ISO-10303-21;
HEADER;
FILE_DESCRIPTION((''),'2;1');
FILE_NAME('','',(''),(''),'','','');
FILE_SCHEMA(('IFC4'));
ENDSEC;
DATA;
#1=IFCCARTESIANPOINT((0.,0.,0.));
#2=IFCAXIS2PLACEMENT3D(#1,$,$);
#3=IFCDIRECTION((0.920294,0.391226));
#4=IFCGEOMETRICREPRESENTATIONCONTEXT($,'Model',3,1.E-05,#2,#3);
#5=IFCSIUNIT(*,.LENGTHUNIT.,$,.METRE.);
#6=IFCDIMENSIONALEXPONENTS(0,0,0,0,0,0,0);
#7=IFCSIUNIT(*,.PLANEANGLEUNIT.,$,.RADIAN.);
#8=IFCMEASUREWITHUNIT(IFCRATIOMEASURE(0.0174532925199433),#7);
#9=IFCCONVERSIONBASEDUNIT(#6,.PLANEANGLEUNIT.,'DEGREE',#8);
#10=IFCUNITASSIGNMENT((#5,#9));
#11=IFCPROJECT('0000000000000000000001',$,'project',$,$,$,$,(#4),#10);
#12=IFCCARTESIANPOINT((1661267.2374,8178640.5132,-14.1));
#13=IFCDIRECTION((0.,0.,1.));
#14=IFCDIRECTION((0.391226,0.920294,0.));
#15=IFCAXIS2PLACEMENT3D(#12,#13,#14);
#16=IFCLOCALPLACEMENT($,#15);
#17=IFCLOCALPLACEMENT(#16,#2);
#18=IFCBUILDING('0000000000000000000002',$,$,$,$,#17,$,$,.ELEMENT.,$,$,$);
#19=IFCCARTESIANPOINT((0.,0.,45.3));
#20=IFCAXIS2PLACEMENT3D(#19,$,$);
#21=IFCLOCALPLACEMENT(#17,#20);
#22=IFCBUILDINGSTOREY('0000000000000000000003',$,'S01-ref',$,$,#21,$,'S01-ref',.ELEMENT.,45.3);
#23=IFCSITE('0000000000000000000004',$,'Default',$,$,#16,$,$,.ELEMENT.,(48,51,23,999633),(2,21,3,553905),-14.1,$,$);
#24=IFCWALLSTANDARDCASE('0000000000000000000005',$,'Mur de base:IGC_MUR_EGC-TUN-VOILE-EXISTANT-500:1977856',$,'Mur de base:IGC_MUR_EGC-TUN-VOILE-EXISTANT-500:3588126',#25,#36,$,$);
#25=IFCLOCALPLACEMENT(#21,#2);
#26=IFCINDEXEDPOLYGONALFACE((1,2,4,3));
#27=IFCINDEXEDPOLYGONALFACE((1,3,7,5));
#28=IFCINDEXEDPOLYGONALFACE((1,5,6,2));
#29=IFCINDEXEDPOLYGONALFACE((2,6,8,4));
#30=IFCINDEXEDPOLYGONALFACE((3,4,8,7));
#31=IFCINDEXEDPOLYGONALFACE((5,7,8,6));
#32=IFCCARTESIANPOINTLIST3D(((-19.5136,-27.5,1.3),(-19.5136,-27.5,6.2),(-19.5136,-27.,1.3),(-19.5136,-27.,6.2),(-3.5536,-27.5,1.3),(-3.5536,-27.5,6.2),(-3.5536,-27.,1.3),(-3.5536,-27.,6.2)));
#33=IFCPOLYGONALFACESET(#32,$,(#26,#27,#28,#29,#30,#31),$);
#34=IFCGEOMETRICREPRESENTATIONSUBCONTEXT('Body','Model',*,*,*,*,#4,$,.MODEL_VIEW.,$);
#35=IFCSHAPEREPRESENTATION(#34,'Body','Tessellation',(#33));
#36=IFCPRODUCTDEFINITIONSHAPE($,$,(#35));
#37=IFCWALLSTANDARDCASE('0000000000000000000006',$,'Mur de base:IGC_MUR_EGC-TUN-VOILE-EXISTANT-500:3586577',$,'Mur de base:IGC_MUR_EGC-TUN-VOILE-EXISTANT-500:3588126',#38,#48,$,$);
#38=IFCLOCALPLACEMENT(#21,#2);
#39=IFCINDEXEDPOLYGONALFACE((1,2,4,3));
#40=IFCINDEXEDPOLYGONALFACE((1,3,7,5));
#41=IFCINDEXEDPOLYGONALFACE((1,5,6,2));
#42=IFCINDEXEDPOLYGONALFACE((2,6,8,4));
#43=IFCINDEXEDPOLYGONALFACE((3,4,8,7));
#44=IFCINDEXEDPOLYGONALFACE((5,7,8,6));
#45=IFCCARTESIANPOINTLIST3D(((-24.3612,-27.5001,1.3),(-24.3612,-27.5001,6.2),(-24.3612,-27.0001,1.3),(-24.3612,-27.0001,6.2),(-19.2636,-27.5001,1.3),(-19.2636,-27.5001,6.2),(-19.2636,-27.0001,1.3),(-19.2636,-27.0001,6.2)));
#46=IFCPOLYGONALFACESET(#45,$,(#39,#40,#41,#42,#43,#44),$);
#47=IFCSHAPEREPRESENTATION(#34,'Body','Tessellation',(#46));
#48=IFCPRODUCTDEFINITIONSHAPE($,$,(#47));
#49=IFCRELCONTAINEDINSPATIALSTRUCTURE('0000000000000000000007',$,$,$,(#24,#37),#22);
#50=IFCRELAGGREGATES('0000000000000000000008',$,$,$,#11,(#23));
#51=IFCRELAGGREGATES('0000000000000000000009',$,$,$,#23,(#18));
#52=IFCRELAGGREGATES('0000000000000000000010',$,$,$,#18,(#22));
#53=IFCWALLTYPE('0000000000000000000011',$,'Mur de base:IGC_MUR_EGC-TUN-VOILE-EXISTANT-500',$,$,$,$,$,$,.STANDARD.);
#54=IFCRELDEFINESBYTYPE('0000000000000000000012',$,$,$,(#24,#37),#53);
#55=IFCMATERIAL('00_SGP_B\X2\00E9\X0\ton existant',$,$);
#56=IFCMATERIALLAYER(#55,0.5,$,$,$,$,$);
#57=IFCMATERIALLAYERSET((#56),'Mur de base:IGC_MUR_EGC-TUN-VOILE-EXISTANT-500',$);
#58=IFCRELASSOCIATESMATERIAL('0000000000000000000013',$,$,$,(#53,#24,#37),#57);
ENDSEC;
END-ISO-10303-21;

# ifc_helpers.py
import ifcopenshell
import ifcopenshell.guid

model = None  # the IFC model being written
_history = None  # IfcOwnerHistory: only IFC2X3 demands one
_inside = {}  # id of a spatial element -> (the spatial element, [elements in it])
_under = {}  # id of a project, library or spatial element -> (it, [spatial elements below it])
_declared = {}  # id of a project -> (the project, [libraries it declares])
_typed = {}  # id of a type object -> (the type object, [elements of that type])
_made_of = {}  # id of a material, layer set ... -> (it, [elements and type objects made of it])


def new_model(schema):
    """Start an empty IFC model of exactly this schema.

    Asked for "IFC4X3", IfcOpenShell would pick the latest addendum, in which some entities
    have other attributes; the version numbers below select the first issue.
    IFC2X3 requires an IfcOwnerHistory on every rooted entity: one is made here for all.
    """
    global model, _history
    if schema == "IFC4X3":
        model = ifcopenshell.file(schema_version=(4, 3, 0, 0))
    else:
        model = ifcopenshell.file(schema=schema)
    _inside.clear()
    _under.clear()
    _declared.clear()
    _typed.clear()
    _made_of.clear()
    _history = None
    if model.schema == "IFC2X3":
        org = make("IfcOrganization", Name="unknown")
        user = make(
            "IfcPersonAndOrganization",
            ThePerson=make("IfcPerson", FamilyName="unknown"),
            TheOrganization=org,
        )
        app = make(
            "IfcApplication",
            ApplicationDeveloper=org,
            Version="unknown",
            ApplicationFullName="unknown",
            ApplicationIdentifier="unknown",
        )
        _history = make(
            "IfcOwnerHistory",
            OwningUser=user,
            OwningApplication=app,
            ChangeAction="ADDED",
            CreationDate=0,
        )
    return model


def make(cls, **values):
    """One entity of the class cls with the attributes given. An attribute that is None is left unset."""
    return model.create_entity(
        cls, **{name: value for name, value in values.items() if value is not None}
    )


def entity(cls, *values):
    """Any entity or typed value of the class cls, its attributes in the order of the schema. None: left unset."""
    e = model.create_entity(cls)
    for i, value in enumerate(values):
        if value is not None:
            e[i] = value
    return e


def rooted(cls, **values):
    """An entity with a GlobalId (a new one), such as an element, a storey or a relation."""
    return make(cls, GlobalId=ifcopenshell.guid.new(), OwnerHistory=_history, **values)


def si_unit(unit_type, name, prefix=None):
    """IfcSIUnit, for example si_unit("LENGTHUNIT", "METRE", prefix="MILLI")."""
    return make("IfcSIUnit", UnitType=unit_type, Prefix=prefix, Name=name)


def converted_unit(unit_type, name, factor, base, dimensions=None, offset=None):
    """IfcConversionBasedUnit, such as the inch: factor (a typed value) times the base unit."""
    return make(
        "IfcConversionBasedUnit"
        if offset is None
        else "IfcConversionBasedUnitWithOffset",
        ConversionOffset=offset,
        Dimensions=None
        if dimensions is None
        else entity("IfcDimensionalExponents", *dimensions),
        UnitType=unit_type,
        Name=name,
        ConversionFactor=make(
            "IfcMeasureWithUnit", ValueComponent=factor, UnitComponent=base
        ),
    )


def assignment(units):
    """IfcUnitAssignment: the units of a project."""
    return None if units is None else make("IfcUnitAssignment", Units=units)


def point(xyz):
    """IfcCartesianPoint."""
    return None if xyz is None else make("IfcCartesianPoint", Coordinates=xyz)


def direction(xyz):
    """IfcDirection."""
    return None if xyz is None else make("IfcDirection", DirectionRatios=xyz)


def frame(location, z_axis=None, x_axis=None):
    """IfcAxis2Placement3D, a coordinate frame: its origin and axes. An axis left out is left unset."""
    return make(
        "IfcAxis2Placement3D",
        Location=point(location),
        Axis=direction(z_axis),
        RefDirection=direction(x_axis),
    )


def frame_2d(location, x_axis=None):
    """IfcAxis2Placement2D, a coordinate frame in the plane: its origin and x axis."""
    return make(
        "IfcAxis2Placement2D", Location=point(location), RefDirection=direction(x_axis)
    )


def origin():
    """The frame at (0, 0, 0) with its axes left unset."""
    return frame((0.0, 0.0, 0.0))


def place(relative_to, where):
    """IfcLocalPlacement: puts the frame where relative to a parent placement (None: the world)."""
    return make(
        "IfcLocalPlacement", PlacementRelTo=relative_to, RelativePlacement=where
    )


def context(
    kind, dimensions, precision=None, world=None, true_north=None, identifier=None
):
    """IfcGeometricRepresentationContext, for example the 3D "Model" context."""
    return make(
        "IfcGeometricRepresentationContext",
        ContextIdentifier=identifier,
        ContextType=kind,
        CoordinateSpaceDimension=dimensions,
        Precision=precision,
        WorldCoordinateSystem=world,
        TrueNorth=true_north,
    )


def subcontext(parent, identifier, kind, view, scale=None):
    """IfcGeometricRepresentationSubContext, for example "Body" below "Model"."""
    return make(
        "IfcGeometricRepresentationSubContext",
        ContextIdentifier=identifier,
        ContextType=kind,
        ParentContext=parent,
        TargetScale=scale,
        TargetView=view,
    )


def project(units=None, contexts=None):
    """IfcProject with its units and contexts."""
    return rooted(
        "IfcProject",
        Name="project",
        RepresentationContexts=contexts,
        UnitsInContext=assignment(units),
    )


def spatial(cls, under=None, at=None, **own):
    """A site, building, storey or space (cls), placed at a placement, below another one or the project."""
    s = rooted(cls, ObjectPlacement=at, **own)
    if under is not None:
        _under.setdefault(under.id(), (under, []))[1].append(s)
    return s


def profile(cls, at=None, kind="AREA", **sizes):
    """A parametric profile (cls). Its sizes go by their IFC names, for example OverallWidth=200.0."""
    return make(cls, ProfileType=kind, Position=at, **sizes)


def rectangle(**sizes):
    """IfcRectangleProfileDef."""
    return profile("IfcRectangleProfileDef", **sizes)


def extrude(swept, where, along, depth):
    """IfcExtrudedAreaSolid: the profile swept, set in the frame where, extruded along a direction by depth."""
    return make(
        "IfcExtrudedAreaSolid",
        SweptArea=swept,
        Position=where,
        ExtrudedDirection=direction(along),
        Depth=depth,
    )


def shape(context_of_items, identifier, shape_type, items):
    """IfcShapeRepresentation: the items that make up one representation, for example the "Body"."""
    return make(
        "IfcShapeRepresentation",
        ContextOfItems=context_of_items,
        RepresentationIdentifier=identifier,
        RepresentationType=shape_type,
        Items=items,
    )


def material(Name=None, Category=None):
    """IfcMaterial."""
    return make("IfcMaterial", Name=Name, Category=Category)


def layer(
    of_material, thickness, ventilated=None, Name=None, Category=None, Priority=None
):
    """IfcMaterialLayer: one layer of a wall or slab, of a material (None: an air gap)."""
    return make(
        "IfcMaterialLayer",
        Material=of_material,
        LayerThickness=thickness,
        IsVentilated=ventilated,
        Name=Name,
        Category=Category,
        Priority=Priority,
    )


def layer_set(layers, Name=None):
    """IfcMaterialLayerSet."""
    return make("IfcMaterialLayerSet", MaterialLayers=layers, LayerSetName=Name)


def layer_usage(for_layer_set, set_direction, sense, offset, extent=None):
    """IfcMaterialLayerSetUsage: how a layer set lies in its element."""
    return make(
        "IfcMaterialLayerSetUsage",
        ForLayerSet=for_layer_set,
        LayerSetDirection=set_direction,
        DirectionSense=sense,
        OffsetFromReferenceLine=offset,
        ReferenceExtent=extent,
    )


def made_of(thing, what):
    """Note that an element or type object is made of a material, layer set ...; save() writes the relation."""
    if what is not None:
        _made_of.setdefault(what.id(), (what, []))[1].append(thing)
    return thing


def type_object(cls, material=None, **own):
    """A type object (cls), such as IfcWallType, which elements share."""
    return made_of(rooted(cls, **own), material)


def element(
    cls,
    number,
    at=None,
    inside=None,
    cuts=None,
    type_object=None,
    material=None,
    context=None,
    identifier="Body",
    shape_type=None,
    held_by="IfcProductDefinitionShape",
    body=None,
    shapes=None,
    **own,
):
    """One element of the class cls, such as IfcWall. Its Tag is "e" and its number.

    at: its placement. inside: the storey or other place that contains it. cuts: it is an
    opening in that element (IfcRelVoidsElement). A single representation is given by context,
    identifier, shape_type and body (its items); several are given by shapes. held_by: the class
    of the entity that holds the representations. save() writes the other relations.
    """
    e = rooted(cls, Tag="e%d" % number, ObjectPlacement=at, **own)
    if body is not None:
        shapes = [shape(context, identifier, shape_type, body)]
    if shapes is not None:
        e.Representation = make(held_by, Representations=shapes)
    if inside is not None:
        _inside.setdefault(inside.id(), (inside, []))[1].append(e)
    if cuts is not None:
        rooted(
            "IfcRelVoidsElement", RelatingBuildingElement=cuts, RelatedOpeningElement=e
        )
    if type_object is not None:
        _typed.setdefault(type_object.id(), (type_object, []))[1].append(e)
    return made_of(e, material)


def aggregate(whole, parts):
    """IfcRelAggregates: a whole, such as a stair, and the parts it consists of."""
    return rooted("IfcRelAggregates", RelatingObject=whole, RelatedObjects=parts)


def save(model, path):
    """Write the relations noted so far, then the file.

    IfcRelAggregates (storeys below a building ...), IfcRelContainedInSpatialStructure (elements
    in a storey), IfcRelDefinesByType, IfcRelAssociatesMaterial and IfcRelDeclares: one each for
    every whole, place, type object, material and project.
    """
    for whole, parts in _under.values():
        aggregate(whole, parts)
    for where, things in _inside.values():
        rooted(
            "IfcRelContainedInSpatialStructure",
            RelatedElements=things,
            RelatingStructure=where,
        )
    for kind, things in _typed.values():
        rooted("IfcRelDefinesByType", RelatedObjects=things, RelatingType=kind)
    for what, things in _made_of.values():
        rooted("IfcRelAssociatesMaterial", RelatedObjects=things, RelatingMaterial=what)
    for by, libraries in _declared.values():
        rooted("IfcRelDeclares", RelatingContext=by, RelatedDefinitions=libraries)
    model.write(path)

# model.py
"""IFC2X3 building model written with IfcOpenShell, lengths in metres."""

from ifc_helpers import new_model, entity, si_unit, converted_unit, direction, frame, frame_2d, origin, place, context, subcontext, project, spatial, rectangle, extrude, material, layer, layer_set, layer_usage, type_object, element, save


model = new_model("IFC2X3")

# Units and contexts
model_context = context("Model", 3, precision=1e-05, world=origin(), true_north=direction((0.920294, 0.391226)))
body_context = subcontext(model_context, "Body", "Model", "MODEL_VIEW")
ifc_project = project(units=[si_unit("LENGTHUNIT", "METRE"), converted_unit("PLANEANGLEUNIT", "DEGREE", entity("IfcRatioMeasure", 0.0174532925199433), si_unit("PLANEANGLEUNIT", "RADIAN"), dimensions=[0, 0, 0, 0, 0, 0, 0])], contexts=[model_context])

# Site, building, storey
site_placement = place(None, frame((1661267.2374, 8178640.5132, -14.1), z_axis=(0.0, 0.0, 1.0), x_axis=(0.391226, 0.920294, 0.0)))
site = spatial("IfcSite", under=ifc_project, at=site_placement, Name="Default", CompositionType="ELEMENT", RefLatitude=(48, 51, 23, 999633), RefLongitude=(2, 21, 3, 553905), RefElevation=-14.1)
building_placement = place(site_placement, origin())
building = spatial("IfcBuilding", under=site, at=building_placement, CompositionType="ELEMENT")
storey_placement = place(building_placement, frame((0.0, 0.0, 45.3)))
storey = spatial("IfcBuildingStorey", under=building, at=storey_placement, Name="S01-ref", LongName="S01-ref", CompositionType="ELEMENT", Elevation=45.3)

# Walls
ifc_material_1 = material(Name="00_SGP_Béton existant")
ifc_layer_1 = layer(ifc_material_1, 0.5)
ifc_layer_set_1 = layer_set([ifc_layer_1], Name="Mur de base:IGC_MUR_EGC-TUN-VOILE-EXISTANT-500")
ifc_layer_usage_1 = layer_usage(ifc_layer_set_1, "AXIS2", "NEGATIVE", 0.25)
wall_type = type_object("IfcWallType", Name="Mur de base:IGC_MUR_EGC-TUN-VOILE-EXISTANT-500", PredefinedType="STANDARD", material=ifc_layer_set_1)
wall_1_placement = place(storey_placement, frame((-19.5136, -27.25, 1.3)))
element("IfcWallStandardCase", 1, at=wall_1_placement, inside=storey, type_object=wall_type, material=ifc_layer_usage_1, Name="Mur de base:IGC_MUR_EGC-TUN-VOILE-EXISTANT-500:1977856", ObjectType="Mur de base:IGC_MUR_EGC-TUN-VOILE-EXISTANT-500:3588126", context=body_context, shape_type="SweptSolid", body=[
    extrude(rectangle(XDim=15.96, YDim=0.5, at=frame_2d((7.98, 0.0), x_axis=(-1.0, 0.0))), origin(), (0.0, 0.0, 1.0), 4.9),
])
ifc_layer_usage_2 = layer_usage(ifc_layer_set_1, "AXIS2", "NEGATIVE", 0.25)
wall_2_placement = place(storey_placement, frame((-24.3612, -27.2501, 1.3)))
element("IfcWallStandardCase", 2, at=wall_2_placement, inside=storey, type_object=wall_type, material=ifc_layer_usage_2, Name="Mur de base:IGC_MUR_EGC-TUN-VOILE-EXISTANT-500:3586577", ObjectType="Mur de base:IGC_MUR_EGC-TUN-VOILE-EXISTANT-500:3588126", context=body_context, shape_type="SweptSolid", body=[
    extrude(rectangle(XDim=5.0976, YDim=0.5, at=frame_2d((2.5488, 0.0), x_axis=(-1.0, 0.0))), origin(), (0.0, 0.0, 1.0), 4.9),
])

save(model, "model.ifc")
